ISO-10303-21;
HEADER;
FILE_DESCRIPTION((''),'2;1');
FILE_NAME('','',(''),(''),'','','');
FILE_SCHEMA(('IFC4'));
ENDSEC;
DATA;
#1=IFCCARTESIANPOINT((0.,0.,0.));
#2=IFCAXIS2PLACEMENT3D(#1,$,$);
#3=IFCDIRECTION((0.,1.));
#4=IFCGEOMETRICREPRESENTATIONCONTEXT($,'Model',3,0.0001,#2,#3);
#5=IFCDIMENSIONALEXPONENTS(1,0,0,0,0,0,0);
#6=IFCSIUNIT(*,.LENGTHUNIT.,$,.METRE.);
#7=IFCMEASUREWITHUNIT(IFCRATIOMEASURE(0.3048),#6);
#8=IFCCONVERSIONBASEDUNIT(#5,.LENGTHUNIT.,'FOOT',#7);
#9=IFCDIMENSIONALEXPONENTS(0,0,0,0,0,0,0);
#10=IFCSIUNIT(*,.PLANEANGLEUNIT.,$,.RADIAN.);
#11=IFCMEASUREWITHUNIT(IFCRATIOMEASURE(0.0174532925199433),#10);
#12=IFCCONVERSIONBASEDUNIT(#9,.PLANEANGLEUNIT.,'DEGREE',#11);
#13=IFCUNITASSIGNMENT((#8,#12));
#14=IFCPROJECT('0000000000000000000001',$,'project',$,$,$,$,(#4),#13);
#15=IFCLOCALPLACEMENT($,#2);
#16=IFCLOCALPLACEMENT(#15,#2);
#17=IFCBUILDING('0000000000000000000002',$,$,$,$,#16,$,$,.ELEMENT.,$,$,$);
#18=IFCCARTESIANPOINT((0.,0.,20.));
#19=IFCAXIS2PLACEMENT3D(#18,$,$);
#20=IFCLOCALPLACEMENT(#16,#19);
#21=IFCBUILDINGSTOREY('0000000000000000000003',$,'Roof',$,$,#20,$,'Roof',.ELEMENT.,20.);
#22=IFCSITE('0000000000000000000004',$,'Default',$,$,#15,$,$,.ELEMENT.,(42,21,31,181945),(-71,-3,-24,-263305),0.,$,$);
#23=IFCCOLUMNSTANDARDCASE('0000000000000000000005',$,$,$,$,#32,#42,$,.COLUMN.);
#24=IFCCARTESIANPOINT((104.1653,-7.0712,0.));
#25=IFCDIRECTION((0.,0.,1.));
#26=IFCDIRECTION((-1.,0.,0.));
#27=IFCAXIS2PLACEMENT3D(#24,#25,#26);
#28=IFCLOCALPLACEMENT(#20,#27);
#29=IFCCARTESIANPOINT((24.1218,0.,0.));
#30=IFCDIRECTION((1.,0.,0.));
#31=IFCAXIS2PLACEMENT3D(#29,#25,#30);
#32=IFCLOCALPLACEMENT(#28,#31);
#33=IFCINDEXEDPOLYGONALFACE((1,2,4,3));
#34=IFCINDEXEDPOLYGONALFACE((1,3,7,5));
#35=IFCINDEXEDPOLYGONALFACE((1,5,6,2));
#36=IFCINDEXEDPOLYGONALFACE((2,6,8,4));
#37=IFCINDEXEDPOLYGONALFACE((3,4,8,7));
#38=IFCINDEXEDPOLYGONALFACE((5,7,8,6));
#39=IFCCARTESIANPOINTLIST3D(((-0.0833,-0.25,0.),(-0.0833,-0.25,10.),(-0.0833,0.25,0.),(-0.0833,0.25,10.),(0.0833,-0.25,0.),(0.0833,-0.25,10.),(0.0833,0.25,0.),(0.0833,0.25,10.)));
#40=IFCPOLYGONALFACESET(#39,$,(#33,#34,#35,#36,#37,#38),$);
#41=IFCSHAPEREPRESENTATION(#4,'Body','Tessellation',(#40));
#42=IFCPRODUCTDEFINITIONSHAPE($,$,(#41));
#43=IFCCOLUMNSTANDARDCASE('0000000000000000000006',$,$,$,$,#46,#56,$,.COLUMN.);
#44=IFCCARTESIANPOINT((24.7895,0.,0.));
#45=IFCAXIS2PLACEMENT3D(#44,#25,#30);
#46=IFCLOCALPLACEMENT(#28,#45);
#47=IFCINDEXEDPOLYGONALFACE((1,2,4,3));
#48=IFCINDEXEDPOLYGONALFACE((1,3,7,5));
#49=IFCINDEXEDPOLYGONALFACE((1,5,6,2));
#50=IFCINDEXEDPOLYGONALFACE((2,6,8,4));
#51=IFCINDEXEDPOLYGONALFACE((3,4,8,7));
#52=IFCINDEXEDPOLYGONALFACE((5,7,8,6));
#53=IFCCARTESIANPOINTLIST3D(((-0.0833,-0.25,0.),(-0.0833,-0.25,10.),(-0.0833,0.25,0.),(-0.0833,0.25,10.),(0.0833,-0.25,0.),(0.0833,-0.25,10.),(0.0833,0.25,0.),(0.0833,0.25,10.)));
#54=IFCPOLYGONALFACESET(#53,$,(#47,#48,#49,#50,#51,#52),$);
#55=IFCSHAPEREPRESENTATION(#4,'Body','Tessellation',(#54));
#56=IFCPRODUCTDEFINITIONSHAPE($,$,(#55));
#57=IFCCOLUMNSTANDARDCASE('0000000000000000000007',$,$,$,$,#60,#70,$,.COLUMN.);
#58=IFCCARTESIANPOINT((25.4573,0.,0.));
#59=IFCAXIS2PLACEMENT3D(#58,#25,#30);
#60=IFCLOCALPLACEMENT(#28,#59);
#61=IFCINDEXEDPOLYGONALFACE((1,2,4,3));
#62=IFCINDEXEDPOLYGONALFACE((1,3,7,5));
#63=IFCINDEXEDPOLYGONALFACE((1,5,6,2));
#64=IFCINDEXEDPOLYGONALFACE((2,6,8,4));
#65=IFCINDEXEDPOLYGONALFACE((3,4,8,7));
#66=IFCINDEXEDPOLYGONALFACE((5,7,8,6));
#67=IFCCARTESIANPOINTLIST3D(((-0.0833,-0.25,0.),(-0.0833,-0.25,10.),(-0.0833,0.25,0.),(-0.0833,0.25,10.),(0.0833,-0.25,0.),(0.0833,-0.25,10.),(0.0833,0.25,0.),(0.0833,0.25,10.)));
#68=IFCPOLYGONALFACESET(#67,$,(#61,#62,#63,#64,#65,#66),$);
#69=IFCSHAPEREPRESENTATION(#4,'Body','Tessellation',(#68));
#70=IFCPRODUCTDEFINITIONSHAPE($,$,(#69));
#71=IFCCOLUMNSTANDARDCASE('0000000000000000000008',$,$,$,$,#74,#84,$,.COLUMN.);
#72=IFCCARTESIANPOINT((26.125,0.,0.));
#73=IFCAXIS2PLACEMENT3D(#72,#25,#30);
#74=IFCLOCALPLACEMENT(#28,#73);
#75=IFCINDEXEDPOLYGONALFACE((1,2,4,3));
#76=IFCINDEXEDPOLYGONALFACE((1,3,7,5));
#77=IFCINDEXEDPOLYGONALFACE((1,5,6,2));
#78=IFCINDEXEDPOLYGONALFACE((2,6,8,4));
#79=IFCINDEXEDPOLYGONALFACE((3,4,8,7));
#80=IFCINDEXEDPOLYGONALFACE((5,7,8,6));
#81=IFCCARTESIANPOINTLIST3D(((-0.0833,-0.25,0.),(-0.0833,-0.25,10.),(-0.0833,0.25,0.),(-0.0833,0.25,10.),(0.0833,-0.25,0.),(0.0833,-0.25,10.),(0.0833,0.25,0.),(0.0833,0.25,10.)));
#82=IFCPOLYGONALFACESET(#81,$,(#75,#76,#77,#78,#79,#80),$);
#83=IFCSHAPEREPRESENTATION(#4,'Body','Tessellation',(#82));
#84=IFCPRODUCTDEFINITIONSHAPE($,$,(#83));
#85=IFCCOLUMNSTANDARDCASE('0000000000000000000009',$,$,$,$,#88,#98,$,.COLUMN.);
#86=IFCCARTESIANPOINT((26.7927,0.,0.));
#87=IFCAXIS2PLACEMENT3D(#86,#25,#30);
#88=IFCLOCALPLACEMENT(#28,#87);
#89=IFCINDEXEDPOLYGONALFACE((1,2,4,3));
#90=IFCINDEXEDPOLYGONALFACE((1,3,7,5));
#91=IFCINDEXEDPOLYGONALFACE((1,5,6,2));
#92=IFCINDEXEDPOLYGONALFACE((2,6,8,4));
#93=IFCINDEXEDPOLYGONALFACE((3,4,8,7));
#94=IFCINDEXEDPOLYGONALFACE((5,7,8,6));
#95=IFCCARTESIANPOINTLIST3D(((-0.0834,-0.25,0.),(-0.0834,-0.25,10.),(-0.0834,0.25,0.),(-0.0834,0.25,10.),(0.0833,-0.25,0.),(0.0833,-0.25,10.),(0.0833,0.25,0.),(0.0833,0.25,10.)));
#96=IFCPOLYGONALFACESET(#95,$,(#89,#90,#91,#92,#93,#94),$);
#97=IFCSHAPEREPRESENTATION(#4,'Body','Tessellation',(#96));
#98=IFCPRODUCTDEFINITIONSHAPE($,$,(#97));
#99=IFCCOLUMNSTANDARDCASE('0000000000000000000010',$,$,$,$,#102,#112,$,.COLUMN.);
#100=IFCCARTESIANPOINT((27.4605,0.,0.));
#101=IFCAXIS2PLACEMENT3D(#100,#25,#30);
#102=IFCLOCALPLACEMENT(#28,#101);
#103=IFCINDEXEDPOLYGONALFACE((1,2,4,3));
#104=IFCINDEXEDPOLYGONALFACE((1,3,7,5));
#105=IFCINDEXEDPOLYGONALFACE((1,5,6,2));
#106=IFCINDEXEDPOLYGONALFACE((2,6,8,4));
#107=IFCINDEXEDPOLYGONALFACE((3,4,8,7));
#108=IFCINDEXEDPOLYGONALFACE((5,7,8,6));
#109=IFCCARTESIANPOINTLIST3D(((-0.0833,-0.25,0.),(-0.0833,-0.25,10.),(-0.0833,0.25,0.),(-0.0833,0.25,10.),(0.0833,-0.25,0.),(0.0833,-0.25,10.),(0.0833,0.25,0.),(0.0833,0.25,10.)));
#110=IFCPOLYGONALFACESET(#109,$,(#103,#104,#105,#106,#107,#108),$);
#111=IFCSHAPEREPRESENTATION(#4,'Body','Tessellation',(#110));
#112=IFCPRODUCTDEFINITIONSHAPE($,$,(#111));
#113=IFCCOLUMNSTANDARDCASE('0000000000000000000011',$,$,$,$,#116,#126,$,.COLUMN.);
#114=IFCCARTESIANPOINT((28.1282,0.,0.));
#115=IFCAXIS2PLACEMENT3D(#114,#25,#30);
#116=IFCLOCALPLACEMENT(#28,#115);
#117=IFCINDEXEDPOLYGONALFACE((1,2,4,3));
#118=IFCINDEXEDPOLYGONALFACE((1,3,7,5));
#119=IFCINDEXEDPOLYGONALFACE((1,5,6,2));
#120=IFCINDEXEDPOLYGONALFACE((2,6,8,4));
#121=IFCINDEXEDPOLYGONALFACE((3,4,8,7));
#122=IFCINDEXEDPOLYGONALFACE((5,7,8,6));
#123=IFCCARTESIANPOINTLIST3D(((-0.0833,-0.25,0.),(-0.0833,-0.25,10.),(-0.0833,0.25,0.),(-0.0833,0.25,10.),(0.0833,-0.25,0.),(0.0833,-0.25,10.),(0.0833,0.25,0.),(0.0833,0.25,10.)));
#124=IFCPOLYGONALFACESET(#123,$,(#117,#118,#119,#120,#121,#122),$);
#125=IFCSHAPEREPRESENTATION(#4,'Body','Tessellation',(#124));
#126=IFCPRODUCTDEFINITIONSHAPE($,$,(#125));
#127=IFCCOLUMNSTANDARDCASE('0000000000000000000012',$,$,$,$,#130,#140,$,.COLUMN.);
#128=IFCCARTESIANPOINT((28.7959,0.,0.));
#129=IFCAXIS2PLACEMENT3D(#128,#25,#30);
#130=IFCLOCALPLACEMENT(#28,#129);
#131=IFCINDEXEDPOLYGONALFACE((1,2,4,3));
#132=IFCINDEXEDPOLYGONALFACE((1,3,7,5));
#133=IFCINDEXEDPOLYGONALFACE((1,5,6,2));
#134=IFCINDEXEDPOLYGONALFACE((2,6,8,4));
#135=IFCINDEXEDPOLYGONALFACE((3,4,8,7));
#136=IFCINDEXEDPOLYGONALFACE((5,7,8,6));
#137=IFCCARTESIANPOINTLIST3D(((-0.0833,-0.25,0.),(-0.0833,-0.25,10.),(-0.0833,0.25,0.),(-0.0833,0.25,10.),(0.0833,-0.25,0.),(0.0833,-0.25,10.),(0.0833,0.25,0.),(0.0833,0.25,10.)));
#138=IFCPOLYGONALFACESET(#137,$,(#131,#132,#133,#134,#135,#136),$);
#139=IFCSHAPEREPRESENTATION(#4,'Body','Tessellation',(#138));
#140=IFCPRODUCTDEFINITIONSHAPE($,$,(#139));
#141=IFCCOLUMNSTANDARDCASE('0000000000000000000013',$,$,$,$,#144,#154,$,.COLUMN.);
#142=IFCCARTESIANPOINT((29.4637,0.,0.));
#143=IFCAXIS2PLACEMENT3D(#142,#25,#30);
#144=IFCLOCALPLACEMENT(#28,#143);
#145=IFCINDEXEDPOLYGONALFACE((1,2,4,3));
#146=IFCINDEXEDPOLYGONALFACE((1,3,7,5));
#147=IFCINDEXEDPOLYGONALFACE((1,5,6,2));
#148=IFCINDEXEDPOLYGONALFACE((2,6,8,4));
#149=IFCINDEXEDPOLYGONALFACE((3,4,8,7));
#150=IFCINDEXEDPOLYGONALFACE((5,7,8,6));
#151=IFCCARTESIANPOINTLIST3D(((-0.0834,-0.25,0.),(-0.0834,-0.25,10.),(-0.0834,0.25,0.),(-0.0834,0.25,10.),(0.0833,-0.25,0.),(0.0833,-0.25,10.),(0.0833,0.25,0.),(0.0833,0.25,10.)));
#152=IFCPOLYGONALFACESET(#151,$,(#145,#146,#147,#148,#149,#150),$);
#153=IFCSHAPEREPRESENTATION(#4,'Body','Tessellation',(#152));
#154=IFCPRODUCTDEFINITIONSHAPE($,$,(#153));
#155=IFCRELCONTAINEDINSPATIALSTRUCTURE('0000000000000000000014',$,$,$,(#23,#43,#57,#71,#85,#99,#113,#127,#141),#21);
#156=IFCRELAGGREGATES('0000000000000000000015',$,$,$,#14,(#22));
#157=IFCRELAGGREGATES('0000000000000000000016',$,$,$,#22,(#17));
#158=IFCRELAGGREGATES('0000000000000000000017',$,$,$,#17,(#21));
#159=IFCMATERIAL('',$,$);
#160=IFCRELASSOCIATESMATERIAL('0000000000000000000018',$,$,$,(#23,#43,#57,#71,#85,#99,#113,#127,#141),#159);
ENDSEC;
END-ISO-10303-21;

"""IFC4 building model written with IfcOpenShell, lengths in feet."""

from ifc_helpers import new_model, entity, si_unit, converted_unit, direction, frame, origin, place, context, project, spatial, rectangle, extrude, material, element, save


model = new_model("IFC4")

# Units and contexts
model_context = context("Model", 3, precision=0.0001, world=origin(), true_north=direction((0.0, 1.0)))
ifc_project = project(units=[converted_unit("LENGTHUNIT", "FOOT", entity("IfcRatioMeasure", 0.3048), si_unit("LENGTHUNIT", "METRE"), dimensions=[1, 0, 0, 0, 0, 0, 0]), converted_unit("PLANEANGLEUNIT", "DEGREE", entity("IfcRatioMeasure", 0.0174532925199433), si_unit("PLANEANGLEUNIT", "RADIAN"), dimensions=[0, 0, 0, 0, 0, 0, 0])], contexts=[model_context])

# Site, building, storey
site_placement = place(None, origin())
site = spatial("IfcSite", under=ifc_project, at=site_placement, Name="Default", CompositionType="ELEMENT", RefLatitude=(42, 21, 31, 181945), RefLongitude=(-71, -3, -24, -263305), RefElevation=0.0)
building_placement = place(site_placement, origin())
building = spatial("IfcBuilding", under=site, at=building_placement, CompositionType="ELEMENT")
storey_placement = place(building_placement, frame((0.0, 0.0, 20.0)))
storey = spatial("IfcBuildingStorey", under=building, at=storey_placement, Name="Roof", LongName="Roof", CompositionType="ELEMENT", Elevation=20.0)

# Columns
ifc_material = material(Name="")
placement = place(storey_placement, frame((104.1653, -7.0712, 0.0), z_axis=(0.0, 0.0, 1.0), x_axis=(-1.0, 0.0, 0.0)))
for number, where, z_axis, x_axis in (
    (1, (24.1218, 0.0, 0.0), (0.0, 0.0, 1.0), (1.0, 0.0, 0.0)),
    (2, (24.7895, 0.0, 0.0), (0.0, 0.0, 1.0), (1.0, 0.0, 0.0)),
    (3, (25.4573, 0.0, 0.0), (0.0, 0.0, 1.0), (1.0, 0.0, 0.0)),
    (4, (26.125, 0.0, 0.0), (0.0, 0.0, 1.0), (1.0, 0.0, 0.0)),
    (5, (26.7927, 0.0, 0.0), (0.0, 0.0, 1.0), (1.0, 0.0, 0.0)),
    (6, (27.4605, 0.0, 0.0), (0.0, 0.0, 1.0), (1.0, 0.0, 0.0)),
    (7, (28.1282, 0.0, 0.0), (0.0, 0.0, 1.0), (1.0, 0.0, 0.0)),
    (8, (28.7959, 0.0, 0.0), (0.0, 0.0, 1.0), (1.0, 0.0, 0.0)),
    (9, (29.4637, 0.0, 0.0), (0.0, 0.0, 1.0), (1.0, 0.0, 0.0)),
):
    element("IfcColumnStandardCase", number, at=place(placement, frame(where, z_axis=z_axis, x_axis=x_axis)), inside=storey, material=ifc_material, PredefinedType="COLUMN", context=model_context, shape_type="SweptSolid", body=[
        extrude(rectangle(XDim=0.1667, YDim=0.5), origin(), (0.0, 0.0, 1.0), 10.0),
    ])

save(model, "model.ifc")
